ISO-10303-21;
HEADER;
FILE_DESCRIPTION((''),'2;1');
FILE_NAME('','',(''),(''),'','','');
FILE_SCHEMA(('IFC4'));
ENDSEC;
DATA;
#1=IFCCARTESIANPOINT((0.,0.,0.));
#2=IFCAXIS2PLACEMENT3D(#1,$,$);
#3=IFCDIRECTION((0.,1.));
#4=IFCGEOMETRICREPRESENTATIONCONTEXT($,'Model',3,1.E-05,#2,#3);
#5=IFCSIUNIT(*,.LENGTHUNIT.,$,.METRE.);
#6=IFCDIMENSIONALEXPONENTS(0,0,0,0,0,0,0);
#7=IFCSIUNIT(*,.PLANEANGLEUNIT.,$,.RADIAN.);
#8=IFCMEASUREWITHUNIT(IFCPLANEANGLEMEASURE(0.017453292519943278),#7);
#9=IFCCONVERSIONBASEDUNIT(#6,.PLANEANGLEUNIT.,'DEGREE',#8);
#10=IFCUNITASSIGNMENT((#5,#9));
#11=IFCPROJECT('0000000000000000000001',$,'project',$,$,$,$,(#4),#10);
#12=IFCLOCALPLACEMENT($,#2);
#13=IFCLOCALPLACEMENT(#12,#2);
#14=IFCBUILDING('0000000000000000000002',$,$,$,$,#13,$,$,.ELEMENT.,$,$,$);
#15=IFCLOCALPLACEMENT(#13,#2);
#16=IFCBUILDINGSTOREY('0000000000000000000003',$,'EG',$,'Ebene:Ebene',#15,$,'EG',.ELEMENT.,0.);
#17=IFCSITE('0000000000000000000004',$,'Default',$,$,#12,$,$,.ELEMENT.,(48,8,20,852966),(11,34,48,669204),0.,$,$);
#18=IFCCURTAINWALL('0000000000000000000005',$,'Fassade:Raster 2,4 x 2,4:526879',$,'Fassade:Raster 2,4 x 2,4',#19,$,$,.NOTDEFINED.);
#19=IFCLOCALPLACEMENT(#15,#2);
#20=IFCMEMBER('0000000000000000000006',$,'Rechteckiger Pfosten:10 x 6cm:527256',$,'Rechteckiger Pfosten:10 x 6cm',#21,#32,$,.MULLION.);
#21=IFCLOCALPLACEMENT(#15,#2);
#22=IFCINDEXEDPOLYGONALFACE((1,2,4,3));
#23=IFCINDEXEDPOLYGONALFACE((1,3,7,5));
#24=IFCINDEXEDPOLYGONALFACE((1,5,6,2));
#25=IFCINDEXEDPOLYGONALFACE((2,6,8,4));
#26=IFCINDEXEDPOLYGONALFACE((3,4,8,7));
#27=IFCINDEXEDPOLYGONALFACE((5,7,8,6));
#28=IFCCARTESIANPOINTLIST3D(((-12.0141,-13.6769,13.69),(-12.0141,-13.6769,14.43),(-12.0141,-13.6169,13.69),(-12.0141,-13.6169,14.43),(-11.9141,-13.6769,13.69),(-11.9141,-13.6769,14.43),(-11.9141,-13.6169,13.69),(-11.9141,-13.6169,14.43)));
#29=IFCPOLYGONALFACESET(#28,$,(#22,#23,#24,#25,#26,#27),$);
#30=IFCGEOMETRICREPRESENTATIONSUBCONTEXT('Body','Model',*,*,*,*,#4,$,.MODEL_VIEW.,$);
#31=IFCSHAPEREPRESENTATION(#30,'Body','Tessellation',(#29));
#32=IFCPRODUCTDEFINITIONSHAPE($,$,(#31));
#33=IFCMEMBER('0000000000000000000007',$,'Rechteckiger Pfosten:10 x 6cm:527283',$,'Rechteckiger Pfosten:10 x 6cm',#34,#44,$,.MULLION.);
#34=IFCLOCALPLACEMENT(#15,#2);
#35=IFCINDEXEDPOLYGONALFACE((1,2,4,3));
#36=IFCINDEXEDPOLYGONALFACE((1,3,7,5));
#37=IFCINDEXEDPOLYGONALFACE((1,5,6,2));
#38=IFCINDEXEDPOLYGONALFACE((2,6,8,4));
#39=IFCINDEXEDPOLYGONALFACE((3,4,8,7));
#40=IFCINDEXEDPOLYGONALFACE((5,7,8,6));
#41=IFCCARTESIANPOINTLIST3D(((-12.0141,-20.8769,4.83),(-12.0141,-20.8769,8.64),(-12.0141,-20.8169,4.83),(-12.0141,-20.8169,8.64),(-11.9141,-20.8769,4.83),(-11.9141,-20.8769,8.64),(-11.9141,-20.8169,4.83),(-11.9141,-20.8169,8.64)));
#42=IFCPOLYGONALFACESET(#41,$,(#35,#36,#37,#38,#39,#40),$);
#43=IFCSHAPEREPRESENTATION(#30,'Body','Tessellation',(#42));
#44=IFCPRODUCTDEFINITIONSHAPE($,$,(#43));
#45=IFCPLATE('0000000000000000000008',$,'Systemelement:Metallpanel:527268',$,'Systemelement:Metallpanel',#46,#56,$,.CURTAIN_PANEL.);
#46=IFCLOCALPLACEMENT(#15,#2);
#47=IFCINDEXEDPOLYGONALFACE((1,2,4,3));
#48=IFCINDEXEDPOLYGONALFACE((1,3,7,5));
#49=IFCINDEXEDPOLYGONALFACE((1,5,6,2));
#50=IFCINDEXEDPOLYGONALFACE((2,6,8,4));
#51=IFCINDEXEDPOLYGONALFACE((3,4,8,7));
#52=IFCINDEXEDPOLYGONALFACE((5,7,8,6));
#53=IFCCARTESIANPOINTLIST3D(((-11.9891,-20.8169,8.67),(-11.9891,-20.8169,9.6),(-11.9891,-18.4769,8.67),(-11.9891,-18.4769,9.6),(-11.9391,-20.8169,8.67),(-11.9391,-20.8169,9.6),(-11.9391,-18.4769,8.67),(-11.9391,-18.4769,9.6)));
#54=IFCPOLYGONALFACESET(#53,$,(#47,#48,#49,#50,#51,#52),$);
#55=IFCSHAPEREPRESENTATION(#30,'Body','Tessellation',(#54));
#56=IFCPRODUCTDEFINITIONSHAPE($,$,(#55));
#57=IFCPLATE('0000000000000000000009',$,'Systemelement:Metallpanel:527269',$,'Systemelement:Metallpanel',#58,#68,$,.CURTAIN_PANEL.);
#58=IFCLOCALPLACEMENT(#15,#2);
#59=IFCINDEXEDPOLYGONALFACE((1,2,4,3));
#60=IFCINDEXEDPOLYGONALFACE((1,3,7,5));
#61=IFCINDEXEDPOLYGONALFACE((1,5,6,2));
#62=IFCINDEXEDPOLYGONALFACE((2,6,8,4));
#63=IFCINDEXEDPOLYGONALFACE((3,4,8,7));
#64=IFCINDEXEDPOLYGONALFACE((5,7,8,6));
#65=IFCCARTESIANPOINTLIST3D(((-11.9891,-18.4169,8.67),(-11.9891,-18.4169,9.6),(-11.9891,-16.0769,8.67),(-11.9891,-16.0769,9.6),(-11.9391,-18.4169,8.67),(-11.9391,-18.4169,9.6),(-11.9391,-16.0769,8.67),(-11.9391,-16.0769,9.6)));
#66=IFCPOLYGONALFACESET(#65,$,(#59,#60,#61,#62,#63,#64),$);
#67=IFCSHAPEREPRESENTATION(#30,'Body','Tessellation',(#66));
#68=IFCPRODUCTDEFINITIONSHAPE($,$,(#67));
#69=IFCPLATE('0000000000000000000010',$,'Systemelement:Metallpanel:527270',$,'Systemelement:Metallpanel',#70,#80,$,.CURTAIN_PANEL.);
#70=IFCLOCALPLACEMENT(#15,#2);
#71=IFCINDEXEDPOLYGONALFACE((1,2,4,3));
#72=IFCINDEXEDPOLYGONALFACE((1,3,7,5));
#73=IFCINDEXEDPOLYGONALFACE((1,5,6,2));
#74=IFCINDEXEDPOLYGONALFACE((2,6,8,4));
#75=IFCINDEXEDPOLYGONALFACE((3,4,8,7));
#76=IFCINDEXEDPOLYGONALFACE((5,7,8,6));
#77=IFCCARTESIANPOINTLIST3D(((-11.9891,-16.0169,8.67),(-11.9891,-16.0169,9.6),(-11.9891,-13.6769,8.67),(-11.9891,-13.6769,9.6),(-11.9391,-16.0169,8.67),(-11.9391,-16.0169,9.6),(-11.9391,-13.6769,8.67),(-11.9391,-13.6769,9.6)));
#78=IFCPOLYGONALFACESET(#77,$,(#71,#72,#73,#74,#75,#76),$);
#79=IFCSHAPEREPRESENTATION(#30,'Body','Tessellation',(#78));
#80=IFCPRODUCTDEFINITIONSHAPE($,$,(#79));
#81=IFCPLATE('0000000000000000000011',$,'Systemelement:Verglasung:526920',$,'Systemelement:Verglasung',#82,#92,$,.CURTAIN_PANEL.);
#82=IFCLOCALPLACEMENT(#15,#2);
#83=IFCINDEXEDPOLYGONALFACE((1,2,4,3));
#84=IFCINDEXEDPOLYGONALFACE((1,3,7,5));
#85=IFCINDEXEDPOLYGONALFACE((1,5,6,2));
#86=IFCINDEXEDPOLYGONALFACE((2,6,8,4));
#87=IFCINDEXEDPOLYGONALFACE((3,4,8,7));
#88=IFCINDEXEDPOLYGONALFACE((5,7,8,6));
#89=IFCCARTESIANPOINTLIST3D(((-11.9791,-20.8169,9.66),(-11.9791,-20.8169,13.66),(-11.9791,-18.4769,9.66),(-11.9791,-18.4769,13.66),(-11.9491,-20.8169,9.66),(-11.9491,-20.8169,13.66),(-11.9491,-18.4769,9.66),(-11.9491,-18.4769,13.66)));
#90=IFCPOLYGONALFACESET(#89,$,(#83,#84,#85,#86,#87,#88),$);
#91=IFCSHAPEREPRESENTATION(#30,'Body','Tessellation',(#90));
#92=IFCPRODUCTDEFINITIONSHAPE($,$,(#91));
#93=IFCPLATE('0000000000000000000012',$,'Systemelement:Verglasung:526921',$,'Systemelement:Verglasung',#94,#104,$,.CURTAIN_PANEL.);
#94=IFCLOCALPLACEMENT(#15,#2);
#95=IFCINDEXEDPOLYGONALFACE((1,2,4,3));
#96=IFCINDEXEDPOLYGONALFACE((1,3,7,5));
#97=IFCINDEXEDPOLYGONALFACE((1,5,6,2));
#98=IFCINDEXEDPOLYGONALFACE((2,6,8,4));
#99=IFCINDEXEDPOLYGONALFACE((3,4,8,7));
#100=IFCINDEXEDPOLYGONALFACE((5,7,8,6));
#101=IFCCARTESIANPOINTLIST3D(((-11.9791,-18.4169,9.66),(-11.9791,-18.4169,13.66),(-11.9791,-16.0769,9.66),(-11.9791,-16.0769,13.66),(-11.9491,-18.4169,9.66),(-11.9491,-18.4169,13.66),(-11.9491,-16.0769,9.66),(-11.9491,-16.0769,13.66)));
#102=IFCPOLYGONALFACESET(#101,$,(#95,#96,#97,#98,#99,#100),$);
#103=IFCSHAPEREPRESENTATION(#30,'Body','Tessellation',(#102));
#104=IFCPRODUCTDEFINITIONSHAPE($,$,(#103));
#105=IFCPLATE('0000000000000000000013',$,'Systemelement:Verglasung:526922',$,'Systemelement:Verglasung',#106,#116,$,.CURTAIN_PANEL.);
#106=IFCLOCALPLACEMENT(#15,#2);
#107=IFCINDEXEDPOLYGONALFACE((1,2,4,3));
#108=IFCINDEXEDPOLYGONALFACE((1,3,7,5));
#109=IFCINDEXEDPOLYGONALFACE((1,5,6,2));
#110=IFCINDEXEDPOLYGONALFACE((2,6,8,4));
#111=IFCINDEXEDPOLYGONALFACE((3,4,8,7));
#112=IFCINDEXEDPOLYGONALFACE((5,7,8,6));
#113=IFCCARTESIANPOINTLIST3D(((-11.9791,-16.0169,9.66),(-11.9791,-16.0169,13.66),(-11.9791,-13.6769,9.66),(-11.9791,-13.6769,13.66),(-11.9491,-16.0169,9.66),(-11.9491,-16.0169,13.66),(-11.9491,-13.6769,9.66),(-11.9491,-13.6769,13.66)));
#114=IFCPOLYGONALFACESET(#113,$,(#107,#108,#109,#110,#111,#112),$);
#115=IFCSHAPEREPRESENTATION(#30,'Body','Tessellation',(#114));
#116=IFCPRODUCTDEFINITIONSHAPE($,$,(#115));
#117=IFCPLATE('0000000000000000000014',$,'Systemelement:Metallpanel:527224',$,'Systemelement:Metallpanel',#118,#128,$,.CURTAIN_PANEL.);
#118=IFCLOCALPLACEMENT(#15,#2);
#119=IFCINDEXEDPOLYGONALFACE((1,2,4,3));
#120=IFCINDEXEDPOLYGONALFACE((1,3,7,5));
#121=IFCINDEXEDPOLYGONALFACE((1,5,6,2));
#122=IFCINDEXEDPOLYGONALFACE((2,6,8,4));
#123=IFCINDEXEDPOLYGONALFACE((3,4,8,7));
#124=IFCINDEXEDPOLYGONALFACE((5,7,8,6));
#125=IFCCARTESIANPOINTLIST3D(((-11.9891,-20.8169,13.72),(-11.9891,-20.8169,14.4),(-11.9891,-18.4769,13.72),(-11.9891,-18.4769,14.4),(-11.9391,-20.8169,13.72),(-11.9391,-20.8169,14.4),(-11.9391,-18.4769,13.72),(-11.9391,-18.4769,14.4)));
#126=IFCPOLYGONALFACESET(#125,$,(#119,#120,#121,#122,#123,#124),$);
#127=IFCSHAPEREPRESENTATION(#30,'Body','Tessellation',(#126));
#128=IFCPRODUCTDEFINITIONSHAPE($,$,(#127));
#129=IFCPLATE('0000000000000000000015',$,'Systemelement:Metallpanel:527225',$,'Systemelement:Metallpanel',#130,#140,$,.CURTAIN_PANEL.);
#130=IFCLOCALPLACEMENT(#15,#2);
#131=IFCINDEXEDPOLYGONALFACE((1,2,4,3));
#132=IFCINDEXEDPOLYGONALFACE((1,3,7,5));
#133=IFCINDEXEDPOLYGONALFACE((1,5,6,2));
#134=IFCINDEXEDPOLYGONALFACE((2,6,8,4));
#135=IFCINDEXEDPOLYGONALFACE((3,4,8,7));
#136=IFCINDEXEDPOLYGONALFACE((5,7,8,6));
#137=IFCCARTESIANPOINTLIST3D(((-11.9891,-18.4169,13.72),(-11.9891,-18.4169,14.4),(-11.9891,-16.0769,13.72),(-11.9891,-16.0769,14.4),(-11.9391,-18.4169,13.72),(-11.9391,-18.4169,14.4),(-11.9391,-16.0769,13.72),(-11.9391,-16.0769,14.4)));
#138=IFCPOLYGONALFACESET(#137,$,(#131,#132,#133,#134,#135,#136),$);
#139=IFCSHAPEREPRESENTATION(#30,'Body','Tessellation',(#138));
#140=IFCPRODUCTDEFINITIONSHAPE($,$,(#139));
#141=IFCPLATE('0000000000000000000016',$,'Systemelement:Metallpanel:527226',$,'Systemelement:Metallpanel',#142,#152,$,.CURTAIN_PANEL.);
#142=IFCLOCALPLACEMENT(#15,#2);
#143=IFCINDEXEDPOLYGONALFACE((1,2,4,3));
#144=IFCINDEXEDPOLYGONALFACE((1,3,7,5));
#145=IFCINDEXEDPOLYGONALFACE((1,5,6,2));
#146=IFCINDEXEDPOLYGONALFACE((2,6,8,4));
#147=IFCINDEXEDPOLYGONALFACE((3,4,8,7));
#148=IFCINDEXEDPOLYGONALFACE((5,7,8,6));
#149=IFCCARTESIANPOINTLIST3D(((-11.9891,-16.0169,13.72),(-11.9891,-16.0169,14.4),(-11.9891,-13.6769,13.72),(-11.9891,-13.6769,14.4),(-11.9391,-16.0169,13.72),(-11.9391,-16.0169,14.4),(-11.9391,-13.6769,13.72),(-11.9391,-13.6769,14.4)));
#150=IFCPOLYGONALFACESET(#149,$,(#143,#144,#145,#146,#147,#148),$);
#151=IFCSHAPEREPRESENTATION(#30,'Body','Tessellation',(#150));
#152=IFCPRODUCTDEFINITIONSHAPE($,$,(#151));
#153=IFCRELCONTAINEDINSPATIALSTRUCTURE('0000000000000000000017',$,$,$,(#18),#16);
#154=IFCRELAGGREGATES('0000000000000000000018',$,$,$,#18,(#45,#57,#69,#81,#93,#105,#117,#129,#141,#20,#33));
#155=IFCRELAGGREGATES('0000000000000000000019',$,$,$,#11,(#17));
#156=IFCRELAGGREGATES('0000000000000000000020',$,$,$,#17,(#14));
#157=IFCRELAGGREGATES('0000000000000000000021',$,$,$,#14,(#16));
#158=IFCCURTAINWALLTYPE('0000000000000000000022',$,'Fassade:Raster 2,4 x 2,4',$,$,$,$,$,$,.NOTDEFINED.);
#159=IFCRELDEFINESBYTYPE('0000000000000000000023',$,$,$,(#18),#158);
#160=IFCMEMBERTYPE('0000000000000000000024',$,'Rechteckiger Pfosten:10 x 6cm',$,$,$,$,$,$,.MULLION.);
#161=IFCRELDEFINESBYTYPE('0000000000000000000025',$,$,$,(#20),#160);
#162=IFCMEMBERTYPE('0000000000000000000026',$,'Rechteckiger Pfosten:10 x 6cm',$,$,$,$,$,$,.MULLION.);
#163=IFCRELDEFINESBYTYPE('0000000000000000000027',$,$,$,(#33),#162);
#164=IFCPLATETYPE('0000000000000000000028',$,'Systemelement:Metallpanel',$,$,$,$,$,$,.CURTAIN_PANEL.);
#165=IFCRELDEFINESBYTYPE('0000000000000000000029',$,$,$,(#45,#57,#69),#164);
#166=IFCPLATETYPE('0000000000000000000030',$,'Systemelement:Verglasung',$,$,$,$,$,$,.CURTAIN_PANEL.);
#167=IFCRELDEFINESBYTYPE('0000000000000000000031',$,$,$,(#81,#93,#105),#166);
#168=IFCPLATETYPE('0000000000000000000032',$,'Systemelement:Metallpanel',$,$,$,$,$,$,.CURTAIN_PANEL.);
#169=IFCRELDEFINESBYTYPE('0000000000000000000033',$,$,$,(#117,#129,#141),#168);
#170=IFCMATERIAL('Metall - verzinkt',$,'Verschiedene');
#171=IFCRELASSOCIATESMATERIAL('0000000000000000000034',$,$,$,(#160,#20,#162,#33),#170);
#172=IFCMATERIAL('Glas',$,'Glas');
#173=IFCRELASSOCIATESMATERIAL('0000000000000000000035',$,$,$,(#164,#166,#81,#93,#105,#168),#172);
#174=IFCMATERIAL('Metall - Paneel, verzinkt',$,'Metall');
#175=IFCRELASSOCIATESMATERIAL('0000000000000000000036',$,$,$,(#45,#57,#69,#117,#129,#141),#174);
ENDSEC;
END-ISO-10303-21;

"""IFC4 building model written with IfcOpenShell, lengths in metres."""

from ifc_helpers import new_model, entity, si_unit, converted_unit, direction, frame, origin, place, context, subcontext, project, spatial, indexed_curve, outline, extrude, source, transform, mapped, material, type_object, type_shapes, element, aggregate, save


model = new_model("IFC4")

# Units and contexts
model_context = context("Model", 3, precision=1e-05, world=origin(), true_north=direction((0.0, 1.0)))
body_context = subcontext(model_context, "Body", "Model", "MODEL_VIEW")
ifc_project = project(units=[si_unit("LENGTHUNIT", "METRE"), converted_unit("PLANEANGLEUNIT", "DEGREE", entity("IfcPlaneAngleMeasure", 0.017453292519943278), si_unit("PLANEANGLEUNIT", "RADIAN"), dimensions=[0, 0, 0, 0, 0, 0, 0])], contexts=[model_context])

# Site, building, storey
site_placement = place(None, origin())
site = spatial("IfcSite", under=ifc_project, at=site_placement, Name="Default", CompositionType="ELEMENT", RefLatitude=(48, 8, 20, 852966), RefLongitude=(11, 34, 48, 669204), RefElevation=0.0)
building_placement = place(site_placement, origin())
building = spatial("IfcBuilding", under=site, at=building_placement, CompositionType="ELEMENT")
storey_placement = place(building_placement, origin())
storey = spatial("IfcBuildingStorey", under=building, at=storey_placement, Name="EG", ObjectType="Ebene:Ebene", LongName="EG", CompositionType="ELEMENT", Elevation=0.0)

# Curtain wall, members, plates
curtain_wall_type = type_object("IfcCurtainWallType", Name="Fassade:Raster 2,4 x 2,4", PredefinedType="NOTDEFINED")
curtain_wall_placement = place(storey_placement, origin())
curtain_wall = element("IfcCurtainWall", 1, at=curtain_wall_placement, inside=storey, type_object=curtain_wall_type, Name="Fassade:Raster 2,4 x 2,4:526879", ObjectType="Fassade:Raster 2,4 x 2,4", PredefinedType="NOTDEFINED")
ifc_material_1 = material(Name="Metall - verzinkt", Category="Verschiedene")
member_type_1 = type_object("IfcMemberType", Name="Rechteckiger Pfosten:10 x 6cm", PredefinedType="MULLION", material=ifc_material_1)
shared_shape_1 = source(origin(), body_context, "Body", "SweptSolid", [
    extrude(outline(indexed_curve([(-0.03, -0.05), (0.03, -0.05), (0.03, 0.05), (-0.03, 0.05), (-0.03, -0.05)], self_intersect=False)), frame((0.0, 0.0, -0.74), z_axis=(0.0, 0.0, 1.0), x_axis=(-1.0, 0.0, 0.0)), (0.0, 0.0, 1.0), 0.74),
])
type_shapes(member_type_1, [shared_shape_1])
member_1_placement = place(curtain_wall_placement, frame((-11.9641, -13.6469, 13.69), z_axis=(0.0, 0.0, -1.0), x_axis=(0.0, 1.0, 0.0)))
member_1 = element("IfcMember", 2, at=member_1_placement, type_object=member_type_1, material=ifc_material_1, Name="Rechteckiger Pfosten:10 x 6cm:527256", ObjectType="Rechteckiger Pfosten:10 x 6cm", PredefinedType="MULLION", context=body_context, shape_type="MappedRepresentation", body=[
    mapped(shared_shape_1, transform((0.0, 0.0, 0.0), scale=1.0)),
])
member_type_2 = type_object("IfcMemberType", Name="Rechteckiger Pfosten:10 x 6cm", PredefinedType="MULLION", material=ifc_material_1)
shared_shape_2 = source(origin(), body_context, "Body", "SweptSolid", [
    extrude(outline(indexed_curve([(-0.03, -0.05), (0.03, -0.05), (0.03, 0.05), (-0.03, 0.05), (-0.03, -0.05)], self_intersect=False)), frame((-0.03, 0.0, -3.81), z_axis=(0.0, 0.0, 1.0), x_axis=(-1.0, 0.0, 0.0)), (0.0, 0.0, 1.0), 3.81),
])
type_shapes(member_type_2, [shared_shape_2])
member_2_placement = place(curtain_wall_placement, frame((-11.9641, -20.8769, 8.64), z_axis=(0.0, 0.0, 1.0), x_axis=(0.0, -1.0, 0.0)))
member_2 = element("IfcMember", 3, at=member_2_placement, type_object=member_type_2, material=ifc_material_1, Name="Rechteckiger Pfosten:10 x 6cm:527283", ObjectType="Rechteckiger Pfosten:10 x 6cm", PredefinedType="MULLION", context=body_context, shape_type="MappedRepresentation", body=[
    mapped(shared_shape_2, transform((0.0, 0.0, 0.0), scale=1.0)),
])
ifc_material_2 = material(Name="Metall - Paneel, verzinkt", Category="Metall")
ifc_material_3 = material(Name="Glas", Category="Glas")
plate_type_1 = type_object("IfcPlateType", Name="Systemelement:Metallpanel", PredefinedType="CURTAIN_PANEL", material=ifc_material_3)
shared_shape_3 = source(origin(), body_context, "Body", "SweptSolid", [
    extrude(outline(indexed_curve([(-0.025, -1.17), (0.025, -1.17), (0.025, 1.17), (-0.025, 1.17), (-0.025, -1.17)], self_intersect=False)), frame((0.0, 0.0, 0.0), z_axis=(0.0, 0.0, 1.0), x_axis=(0.0, 1.0, 0.0)), (0.0, 0.0, 1.0), 0.93),
])
type_shapes(plate_type_1, [shared_shape_3])
plate_1_placement = place(curtain_wall_placement, frame((-11.9641, -19.6469, 8.67), z_axis=(0.0, 0.0, 1.0), x_axis=(0.0, 1.0, 0.0)))
plate_1 = element("IfcPlate", 4, at=plate_1_placement, type_object=plate_type_1, material=ifc_material_2, Name="Systemelement:Metallpanel:527268", ObjectType="Systemelement:Metallpanel", PredefinedType="CURTAIN_PANEL", context=body_context, shape_type="MappedRepresentation", body=[
    mapped(shared_shape_3, transform((0.0, 0.0, 0.0), scale=1.0)),
])
plate_2_placement = place(curtain_wall_placement, frame((-11.9641, -17.2469, 8.67), z_axis=(0.0, 0.0, 1.0), x_axis=(0.0, 1.0, 0.0)))
plate_2 = element("IfcPlate", 5, at=plate_2_placement, type_object=plate_type_1, material=ifc_material_2, Name="Systemelement:Metallpanel:527269", ObjectType="Systemelement:Metallpanel", PredefinedType="CURTAIN_PANEL", context=body_context, shape_type="MappedRepresentation", body=[
    mapped(shared_shape_3, transform((0.0, 0.0, 0.0), scale=1.0)),
])
plate_3_placement = place(curtain_wall_placement, frame((-11.9641, -14.8469, 8.67), z_axis=(0.0, 0.0, 1.0), x_axis=(0.0, 1.0, 0.0)))
plate_3 = element("IfcPlate", 6, at=plate_3_placement, type_object=plate_type_1, material=ifc_material_2, Name="Systemelement:Metallpanel:527270", ObjectType="Systemelement:Metallpanel", PredefinedType="CURTAIN_PANEL", context=body_context, shape_type="MappedRepresentation", body=[
    mapped(shared_shape_3, transform((0.0, 0.0, 0.0), scale=1.0)),
])
plate_type_2 = type_object("IfcPlateType", Name="Systemelement:Verglasung", PredefinedType="CURTAIN_PANEL", material=ifc_material_3)
shared_shape_4 = source(origin(), body_context, "Body", "SweptSolid", [
    extrude(outline(indexed_curve([(-0.015, -1.17), (0.015, -1.17), (0.015, 1.17), (-0.015, 1.17), (-0.015, -1.17)], self_intersect=False)), frame((0.0, 0.0, 0.0), z_axis=(0.0, 0.0, 1.0), x_axis=(0.0, 1.0, 0.0)), (0.0, 0.0, 1.0), 4.0),
])
type_shapes(plate_type_2, [shared_shape_4])
plate_4_placement = place(curtain_wall_placement, frame((-11.9641, -19.6469, 9.66), z_axis=(0.0, 0.0, 1.0), x_axis=(0.0, 1.0, 0.0)))
plate_4 = element("IfcPlate", 7, at=plate_4_placement, type_object=plate_type_2, material=ifc_material_3, Name="Systemelement:Verglasung:526920", ObjectType="Systemelement:Verglasung", PredefinedType="CURTAIN_PANEL", context=body_context, shape_type="MappedRepresentation", body=[
    mapped(shared_shape_4, transform((0.0, 0.0, 0.0), scale=1.0)),
])
plate_5_placement = place(curtain_wall_placement, frame((-11.9641, -17.2469, 9.66), z_axis=(0.0, 0.0, 1.0), x_axis=(0.0, 1.0, 0.0)))
plate_5 = element("IfcPlate", 8, at=plate_5_placement, type_object=plate_type_2, material=ifc_material_3, Name="Systemelement:Verglasung:526921", ObjectType="Systemelement:Verglasung", PredefinedType="CURTAIN_PANEL", context=body_context, shape_type="MappedRepresentation", body=[
    mapped(shared_shape_4, transform((0.0, 0.0, 0.0), scale=1.0)),
])
plate_6_placement = place(curtain_wall_placement, frame((-11.9641, -14.8469, 9.66), z_axis=(0.0, 0.0, 1.0), x_axis=(0.0, 1.0, 0.0)))
plate_6 = element("IfcPlate", 9, at=plate_6_placement, type_object=plate_type_2, material=ifc_material_3, Name="Systemelement:Verglasung:526922", ObjectType="Systemelement:Verglasung", PredefinedType="CURTAIN_PANEL", context=body_context, shape_type="MappedRepresentation", body=[
    mapped(shared_shape_4, transform((0.0, 0.0, 0.0), scale=1.0)),
])
plate_type_3 = type_object("IfcPlateType", Name="Systemelement:Metallpanel", PredefinedType="CURTAIN_PANEL", material=ifc_material_3)
shared_shape_5 = source(origin(), body_context, "Body", "SweptSolid", [
    extrude(outline(indexed_curve([(-0.025, -1.17), (0.025, -1.17), (0.025, 1.17), (-0.025, 1.17), (-0.025, -1.17)], self_intersect=False)), frame((0.0, 0.0, 0.0), z_axis=(0.0, 0.0, 1.0), x_axis=(0.0, 1.0, 0.0)), (0.0, 0.0, 1.0), 0.68),
])
type_shapes(plate_type_3, [shared_shape_5])
plate_7_placement = place(curtain_wall_placement, frame((-11.9641, -19.6469, 13.72), z_axis=(0.0, 0.0, 1.0), x_axis=(0.0, 1.0, 0.0)))
plate_7 = element("IfcPlate", 10, at=plate_7_placement, type_object=plate_type_3, material=ifc_material_2, Name="Systemelement:Metallpanel:527224", ObjectType="Systemelement:Metallpanel", PredefinedType="CURTAIN_PANEL", context=body_context, shape_type="MappedRepresentation", body=[
    mapped(shared_shape_5, transform((0.0, 0.0, 0.0), scale=1.0)),
])
plate_8_placement = place(curtain_wall_placement, frame((-11.9641, -17.2469, 13.72), z_axis=(0.0, 0.0, 1.0), x_axis=(0.0, 1.0, 0.0)))
plate_8 = element("IfcPlate", 11, at=plate_8_placement, type_object=plate_type_3, material=ifc_material_2, Name="Systemelement:Metallpanel:527225", ObjectType="Systemelement:Metallpanel", PredefinedType="CURTAIN_PANEL", context=body_context, shape_type="MappedRepresentation", body=[
    mapped(shared_shape_5, transform((0.0, 0.0, 0.0), scale=1.0)),
])
plate_9_placement = place(curtain_wall_placement, frame((-11.9641, -14.8469, 13.72), z_axis=(0.0, 0.0, 1.0), x_axis=(0.0, 1.0, 0.0)))
plate_9 = element("IfcPlate", 12, at=plate_9_placement, type_object=plate_type_3, material=ifc_material_2, Name="Systemelement:Metallpanel:527226", ObjectType="Systemelement:Metallpanel", PredefinedType="CURTAIN_PANEL", context=body_context, shape_type="MappedRepresentation", body=[
    mapped(shared_shape_5, transform((0.0, 0.0, 0.0), scale=1.0)),
])
aggregate(curtain_wall, [plate_1, plate_2, plate_3, plate_4, plate_5, plate_6, plate_7, plate_8, plate_9, member_1, member_2])

save(model, "model.ifc")
